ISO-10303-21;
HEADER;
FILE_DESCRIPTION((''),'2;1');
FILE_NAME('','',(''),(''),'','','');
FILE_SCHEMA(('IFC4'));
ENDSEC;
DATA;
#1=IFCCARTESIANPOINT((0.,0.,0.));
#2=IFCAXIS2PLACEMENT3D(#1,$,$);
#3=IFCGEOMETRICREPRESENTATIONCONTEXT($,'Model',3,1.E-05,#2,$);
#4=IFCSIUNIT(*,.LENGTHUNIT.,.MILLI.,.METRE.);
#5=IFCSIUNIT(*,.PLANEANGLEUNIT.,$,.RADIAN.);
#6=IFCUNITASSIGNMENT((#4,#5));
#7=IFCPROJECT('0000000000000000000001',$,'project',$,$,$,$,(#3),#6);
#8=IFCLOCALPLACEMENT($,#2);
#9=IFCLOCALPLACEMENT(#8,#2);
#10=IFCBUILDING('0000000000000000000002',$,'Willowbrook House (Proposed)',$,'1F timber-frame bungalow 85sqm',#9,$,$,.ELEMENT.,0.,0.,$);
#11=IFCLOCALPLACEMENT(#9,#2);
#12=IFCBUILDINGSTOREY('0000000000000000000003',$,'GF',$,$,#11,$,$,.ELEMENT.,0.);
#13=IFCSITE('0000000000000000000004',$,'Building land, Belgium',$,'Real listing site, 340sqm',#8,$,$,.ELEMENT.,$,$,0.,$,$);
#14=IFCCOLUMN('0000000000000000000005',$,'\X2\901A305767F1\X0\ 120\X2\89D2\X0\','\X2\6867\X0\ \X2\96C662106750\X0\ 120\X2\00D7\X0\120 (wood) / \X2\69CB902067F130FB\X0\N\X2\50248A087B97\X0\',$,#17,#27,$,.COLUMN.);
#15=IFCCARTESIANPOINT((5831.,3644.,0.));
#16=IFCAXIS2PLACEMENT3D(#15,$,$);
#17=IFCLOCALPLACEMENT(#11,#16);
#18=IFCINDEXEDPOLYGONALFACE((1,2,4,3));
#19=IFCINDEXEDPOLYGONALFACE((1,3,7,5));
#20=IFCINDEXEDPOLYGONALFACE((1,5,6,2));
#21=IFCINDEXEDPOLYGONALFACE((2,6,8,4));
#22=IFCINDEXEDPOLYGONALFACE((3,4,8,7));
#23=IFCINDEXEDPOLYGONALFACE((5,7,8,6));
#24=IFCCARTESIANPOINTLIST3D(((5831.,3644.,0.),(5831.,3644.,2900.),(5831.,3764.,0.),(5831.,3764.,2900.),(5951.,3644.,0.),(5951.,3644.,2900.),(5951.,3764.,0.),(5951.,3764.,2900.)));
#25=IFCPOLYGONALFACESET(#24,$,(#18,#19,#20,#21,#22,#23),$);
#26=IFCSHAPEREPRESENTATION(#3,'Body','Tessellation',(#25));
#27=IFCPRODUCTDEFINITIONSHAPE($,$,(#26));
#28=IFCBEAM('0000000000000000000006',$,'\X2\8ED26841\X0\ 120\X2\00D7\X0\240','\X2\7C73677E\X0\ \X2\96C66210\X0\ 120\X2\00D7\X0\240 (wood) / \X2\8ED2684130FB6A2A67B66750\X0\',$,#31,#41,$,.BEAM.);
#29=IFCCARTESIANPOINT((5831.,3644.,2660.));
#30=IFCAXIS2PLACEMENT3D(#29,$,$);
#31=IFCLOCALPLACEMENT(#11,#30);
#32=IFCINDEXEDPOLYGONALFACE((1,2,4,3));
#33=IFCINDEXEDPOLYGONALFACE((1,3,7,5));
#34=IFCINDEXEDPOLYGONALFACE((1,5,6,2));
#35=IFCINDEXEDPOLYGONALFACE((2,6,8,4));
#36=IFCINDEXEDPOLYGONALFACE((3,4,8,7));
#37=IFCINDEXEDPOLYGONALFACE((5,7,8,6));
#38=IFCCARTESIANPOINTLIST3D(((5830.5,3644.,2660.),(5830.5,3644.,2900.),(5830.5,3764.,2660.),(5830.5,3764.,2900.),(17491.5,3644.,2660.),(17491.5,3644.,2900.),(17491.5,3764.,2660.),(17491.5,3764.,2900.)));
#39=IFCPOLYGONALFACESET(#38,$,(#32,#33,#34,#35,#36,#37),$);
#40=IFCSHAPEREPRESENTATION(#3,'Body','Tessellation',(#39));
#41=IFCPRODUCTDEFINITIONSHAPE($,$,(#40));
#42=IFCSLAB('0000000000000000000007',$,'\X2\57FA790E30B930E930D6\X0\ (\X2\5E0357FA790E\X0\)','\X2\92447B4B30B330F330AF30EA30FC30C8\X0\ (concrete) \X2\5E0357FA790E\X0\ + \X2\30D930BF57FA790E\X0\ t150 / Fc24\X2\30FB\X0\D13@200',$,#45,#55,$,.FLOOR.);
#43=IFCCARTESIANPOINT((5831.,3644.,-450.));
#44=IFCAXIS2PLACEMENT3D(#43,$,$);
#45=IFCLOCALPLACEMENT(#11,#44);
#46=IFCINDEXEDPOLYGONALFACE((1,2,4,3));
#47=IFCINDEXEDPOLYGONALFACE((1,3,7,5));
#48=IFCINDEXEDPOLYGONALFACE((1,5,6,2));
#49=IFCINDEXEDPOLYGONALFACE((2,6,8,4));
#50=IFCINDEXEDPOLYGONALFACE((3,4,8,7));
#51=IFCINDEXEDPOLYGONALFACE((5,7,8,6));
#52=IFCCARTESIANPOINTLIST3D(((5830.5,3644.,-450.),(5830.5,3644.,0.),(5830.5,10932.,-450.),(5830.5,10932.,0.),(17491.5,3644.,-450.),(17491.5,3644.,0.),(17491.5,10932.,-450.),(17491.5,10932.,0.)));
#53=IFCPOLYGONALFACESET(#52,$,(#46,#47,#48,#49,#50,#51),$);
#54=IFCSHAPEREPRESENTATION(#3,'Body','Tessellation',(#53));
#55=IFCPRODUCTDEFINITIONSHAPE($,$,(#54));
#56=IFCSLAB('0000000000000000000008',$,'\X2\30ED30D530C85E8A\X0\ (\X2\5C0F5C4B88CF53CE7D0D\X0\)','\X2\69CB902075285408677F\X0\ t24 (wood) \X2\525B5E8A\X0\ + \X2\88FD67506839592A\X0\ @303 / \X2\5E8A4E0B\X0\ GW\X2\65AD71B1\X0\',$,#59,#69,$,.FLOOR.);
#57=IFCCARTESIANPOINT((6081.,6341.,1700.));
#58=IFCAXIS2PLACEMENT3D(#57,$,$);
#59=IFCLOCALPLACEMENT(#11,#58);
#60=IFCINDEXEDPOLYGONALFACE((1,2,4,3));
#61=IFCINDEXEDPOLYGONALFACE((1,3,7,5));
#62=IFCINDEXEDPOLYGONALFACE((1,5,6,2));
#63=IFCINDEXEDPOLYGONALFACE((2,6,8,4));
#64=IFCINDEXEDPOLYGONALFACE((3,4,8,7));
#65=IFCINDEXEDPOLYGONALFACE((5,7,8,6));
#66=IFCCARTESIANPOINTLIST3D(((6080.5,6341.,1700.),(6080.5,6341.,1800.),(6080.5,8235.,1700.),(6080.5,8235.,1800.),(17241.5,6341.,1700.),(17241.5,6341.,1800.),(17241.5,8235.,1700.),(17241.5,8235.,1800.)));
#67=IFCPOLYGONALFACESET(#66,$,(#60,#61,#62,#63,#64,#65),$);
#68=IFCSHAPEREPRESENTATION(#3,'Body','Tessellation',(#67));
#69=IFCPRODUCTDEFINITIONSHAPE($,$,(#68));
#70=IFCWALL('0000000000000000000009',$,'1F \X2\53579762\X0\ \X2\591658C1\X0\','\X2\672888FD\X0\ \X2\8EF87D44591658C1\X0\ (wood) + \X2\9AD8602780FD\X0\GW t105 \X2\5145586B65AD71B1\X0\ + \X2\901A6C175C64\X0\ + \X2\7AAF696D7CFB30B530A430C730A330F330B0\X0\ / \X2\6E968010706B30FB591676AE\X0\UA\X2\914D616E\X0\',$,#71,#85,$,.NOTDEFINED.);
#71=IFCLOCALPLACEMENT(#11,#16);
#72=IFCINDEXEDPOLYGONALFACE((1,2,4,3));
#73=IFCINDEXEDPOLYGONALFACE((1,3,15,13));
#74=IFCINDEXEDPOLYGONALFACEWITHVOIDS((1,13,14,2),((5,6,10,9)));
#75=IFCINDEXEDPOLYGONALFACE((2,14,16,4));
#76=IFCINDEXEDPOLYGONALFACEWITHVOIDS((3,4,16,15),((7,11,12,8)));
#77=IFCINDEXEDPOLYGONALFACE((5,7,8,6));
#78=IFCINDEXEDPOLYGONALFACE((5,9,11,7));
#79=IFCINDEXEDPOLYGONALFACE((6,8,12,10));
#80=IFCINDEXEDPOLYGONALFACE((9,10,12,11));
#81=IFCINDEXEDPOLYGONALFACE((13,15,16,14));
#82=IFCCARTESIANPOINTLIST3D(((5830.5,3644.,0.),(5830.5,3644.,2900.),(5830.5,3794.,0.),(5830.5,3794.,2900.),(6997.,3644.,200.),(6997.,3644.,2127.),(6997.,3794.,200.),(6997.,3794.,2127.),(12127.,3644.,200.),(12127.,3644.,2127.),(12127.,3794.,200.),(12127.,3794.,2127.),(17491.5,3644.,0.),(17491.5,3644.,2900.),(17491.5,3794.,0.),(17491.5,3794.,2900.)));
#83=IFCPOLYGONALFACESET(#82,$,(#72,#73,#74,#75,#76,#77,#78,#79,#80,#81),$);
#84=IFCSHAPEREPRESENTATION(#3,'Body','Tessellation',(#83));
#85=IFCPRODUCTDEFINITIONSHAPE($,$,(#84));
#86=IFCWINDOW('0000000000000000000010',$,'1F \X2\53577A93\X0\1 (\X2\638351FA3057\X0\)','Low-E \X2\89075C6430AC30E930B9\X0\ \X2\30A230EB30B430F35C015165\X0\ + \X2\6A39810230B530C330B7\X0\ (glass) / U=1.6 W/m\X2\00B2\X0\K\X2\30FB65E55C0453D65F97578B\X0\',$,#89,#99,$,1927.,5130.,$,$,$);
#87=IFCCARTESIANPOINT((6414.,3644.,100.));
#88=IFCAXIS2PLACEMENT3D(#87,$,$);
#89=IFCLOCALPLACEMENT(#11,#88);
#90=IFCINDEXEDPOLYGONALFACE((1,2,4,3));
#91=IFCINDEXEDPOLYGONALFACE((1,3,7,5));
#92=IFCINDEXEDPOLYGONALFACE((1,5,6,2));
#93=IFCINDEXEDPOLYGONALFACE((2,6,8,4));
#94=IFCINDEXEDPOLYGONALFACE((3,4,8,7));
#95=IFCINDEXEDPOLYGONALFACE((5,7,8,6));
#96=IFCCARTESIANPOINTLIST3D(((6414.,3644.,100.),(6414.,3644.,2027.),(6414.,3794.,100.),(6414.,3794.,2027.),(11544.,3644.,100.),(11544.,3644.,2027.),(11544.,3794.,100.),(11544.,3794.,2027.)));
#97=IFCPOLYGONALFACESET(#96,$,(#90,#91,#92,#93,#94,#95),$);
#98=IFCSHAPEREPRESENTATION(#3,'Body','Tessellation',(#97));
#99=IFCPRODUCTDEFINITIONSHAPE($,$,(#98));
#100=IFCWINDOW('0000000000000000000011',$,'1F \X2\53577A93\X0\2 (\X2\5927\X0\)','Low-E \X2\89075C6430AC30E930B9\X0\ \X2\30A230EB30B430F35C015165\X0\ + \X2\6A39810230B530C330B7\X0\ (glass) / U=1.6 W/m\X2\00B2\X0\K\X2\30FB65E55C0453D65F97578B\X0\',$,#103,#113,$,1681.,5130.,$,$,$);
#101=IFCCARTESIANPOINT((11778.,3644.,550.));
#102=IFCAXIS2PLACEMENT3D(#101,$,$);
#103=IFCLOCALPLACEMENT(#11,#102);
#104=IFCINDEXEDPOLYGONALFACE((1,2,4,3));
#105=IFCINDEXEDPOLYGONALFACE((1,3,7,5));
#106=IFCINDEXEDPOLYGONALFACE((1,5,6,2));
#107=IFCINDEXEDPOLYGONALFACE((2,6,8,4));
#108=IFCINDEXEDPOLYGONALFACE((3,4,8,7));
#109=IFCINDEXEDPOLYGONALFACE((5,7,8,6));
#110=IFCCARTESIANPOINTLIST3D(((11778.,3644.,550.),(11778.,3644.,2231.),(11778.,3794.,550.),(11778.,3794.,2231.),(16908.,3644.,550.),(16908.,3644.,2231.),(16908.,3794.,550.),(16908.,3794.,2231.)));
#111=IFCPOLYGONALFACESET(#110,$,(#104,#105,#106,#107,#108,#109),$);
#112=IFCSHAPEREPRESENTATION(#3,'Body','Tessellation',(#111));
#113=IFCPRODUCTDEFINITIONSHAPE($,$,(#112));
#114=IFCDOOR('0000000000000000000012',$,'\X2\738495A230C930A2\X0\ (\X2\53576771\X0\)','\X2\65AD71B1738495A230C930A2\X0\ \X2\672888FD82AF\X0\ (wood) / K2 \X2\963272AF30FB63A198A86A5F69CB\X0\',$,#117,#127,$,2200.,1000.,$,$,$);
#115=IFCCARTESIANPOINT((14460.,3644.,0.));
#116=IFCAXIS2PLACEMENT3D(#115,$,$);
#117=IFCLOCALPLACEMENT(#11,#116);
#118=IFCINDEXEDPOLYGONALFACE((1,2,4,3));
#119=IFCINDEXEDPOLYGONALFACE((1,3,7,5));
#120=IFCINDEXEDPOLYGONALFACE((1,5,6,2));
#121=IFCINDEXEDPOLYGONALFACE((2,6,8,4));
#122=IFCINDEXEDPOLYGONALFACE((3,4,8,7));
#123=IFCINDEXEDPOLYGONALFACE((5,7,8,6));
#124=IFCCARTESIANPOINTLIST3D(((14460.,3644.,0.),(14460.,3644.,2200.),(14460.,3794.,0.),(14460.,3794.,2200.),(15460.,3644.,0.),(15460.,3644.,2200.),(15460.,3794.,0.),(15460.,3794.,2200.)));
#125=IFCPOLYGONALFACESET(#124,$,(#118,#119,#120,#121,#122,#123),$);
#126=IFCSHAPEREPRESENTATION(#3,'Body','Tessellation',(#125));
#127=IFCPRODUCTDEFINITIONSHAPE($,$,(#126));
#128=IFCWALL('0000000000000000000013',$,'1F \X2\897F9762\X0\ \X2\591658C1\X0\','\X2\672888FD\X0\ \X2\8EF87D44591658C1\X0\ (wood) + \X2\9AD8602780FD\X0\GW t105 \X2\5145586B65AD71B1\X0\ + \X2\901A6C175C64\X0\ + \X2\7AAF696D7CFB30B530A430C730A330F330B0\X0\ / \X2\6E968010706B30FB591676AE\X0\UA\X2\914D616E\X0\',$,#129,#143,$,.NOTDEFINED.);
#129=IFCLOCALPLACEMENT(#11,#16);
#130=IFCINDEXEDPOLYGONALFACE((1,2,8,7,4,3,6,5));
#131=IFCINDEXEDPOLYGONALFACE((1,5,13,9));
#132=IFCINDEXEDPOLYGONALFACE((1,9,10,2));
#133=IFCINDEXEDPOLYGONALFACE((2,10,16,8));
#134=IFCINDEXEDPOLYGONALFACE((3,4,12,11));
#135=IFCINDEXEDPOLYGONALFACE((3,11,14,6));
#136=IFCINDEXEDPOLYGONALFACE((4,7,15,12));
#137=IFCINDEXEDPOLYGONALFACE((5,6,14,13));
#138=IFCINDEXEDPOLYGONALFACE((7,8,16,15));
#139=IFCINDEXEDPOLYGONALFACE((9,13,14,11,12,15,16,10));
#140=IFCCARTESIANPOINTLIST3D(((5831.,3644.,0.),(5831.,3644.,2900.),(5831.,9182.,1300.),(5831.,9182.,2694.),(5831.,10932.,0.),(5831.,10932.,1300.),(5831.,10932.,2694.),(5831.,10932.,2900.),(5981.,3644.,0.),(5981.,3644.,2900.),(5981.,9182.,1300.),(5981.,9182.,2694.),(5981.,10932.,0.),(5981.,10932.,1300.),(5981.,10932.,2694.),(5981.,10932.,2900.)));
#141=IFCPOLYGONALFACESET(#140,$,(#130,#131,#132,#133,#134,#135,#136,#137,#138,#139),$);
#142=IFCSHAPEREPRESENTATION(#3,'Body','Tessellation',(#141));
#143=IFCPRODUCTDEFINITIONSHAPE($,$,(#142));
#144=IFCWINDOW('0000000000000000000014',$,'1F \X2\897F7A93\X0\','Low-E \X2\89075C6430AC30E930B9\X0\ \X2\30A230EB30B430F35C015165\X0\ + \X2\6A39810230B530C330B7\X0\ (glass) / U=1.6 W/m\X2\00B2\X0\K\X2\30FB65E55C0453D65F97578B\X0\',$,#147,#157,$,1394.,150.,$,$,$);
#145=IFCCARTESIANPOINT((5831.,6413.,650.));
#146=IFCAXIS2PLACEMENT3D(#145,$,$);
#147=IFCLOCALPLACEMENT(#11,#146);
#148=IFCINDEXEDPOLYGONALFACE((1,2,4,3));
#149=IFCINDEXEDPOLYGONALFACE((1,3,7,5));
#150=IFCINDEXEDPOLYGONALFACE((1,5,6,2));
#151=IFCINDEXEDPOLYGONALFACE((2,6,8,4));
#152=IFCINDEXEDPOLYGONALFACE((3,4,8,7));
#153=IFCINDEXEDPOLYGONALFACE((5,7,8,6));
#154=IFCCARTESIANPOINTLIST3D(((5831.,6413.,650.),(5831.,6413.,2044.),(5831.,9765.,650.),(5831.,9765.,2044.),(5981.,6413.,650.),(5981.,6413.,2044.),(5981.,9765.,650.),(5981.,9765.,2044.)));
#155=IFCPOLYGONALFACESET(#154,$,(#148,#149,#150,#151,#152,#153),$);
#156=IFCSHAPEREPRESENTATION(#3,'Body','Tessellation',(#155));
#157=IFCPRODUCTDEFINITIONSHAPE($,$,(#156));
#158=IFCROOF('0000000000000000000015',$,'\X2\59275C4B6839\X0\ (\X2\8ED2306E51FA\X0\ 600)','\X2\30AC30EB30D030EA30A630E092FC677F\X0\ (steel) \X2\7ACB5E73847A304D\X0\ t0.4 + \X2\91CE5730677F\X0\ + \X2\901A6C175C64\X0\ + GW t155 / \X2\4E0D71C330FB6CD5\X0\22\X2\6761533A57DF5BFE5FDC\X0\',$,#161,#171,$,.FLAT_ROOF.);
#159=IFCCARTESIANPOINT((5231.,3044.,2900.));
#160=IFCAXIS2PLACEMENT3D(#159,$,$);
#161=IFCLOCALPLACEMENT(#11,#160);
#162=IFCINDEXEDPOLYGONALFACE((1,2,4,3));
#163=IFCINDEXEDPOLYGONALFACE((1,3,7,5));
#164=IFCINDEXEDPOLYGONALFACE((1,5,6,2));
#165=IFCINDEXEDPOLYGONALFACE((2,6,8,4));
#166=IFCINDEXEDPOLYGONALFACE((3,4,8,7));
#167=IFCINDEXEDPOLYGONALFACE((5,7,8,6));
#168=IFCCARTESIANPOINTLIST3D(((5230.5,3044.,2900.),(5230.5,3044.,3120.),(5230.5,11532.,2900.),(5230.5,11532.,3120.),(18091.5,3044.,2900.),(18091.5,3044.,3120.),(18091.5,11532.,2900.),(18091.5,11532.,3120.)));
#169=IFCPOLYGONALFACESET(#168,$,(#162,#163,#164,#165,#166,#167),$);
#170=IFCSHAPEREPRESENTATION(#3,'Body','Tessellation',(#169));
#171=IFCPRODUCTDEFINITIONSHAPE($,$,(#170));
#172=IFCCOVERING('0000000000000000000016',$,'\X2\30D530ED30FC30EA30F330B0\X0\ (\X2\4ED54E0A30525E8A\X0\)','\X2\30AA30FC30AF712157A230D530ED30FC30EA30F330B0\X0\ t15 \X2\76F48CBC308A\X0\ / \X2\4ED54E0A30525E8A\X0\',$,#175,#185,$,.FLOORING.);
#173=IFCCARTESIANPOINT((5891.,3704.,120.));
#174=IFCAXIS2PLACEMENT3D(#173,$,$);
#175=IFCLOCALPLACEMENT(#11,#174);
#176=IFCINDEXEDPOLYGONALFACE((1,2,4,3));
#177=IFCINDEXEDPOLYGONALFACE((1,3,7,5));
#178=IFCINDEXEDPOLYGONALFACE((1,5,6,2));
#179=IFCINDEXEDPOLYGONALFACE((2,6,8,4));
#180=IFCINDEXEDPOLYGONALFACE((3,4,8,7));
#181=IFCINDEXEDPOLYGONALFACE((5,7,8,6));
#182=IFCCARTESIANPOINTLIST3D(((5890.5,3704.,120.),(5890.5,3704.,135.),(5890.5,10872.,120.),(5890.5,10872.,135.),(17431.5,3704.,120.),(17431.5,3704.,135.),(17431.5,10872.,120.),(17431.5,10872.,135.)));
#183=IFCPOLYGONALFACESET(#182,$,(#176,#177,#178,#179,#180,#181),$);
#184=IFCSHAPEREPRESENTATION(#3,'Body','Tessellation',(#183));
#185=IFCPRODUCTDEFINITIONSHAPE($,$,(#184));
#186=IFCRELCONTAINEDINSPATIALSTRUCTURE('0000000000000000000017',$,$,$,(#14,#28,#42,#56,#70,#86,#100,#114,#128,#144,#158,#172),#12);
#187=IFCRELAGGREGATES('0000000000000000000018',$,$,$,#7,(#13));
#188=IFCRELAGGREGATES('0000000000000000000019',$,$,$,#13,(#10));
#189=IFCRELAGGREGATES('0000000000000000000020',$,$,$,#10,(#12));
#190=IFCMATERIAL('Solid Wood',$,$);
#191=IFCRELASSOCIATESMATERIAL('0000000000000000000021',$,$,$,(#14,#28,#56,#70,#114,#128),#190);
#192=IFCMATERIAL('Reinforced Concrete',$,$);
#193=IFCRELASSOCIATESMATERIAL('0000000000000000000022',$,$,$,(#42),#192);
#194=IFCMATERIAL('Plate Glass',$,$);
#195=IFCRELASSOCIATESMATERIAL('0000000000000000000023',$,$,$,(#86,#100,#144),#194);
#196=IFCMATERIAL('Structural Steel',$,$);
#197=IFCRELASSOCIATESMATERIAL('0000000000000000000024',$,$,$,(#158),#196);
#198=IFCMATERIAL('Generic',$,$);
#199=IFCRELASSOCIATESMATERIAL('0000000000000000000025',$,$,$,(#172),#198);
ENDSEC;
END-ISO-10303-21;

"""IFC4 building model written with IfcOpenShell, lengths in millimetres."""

from ifc_helpers import new_model, si_unit, frame, frame_2d, origin, place, context, project, spatial, rectangle, extrude, material, element, fill, save


model = new_model("IFC4")

# Units and contexts
model_context = context("Model", 3, precision=1e-05, world=origin())
ifc_project = project(units=[si_unit("LENGTHUNIT", "METRE", prefix="MILLI"), si_unit("PLANEANGLEUNIT", "RADIAN")], contexts=[model_context])

# Site, building, storey
site_placement = place(None, origin())
site = spatial("IfcSite", under=ifc_project, at=site_placement, Name="Building land, Belgium", ObjectType="Real listing site, 340sqm", CompositionType="ELEMENT", RefElevation=0.0)
building_placement = place(site_placement, origin())
building = spatial("IfcBuilding", under=site, at=building_placement, Name="Willowbrook House (Proposed)", ObjectType="1F timber-frame bungalow 85sqm", CompositionType="ELEMENT", ElevationOfRefHeight=0.0, ElevationOfTerrain=0.0)
storey_placement = place(building_placement, origin())
storey = spatial("IfcBuildingStorey", under=building, at=storey_placement, Name="GF", CompositionType="ELEMENT", Elevation=0.0)

# Column
ifc_material_1 = material(Name="Solid Wood")
column_1_placement = place(storey_placement, frame((5831.0, 3644.0, 0.0)))
element("IfcColumn", 1, at=column_1_placement, inside=storey, material=ifc_material_1, Name="通し柱 120角", Description="桧 集成材 120×120 (wood) / 構造柱・N値計算", PredefinedType="COLUMN", context=model_context, shape_type="SweptSolid", body=[
    extrude(rectangle(XDim=120.0, YDim=120.0, at=frame_2d((60.0, 60.0))), frame((5831.0, 3644.0, 0.0)), (0.0, 0.0, 1.0), 2900.0),
])

# Beam
beam_1_placement = place(storey_placement, frame((5831.0, 3644.0, 2660.0)))
element("IfcBeam", 2, at=beam_1_placement, inside=storey, material=ifc_material_1, Name="軒桁 120×240", Description="米松 集成 120×240 (wood) / 軒桁・横架材", PredefinedType="BEAM", context=model_context, shape_type="SweptSolid", body=[
    extrude(rectangle(XDim=11661.0, YDim=120.0, at=frame_2d((5830.0, 60.0))), frame((5831.0, 3644.0, 2660.0)), (0.0, 0.0, 1.0), 240.0),
])

# Slabs
ifc_material_2 = material(Name="Reinforced Concrete")
slab_1_placement = place(storey_placement, frame((5831.0, 3644.0, -450.0)))
element("IfcSlab", 3, at=slab_1_placement, inside=storey, material=ifc_material_2, Name="基礎スラブ (布基礎)", Description="鉄筋コンクリート (concrete) 布基礎 + ベタ基礎 t150 / Fc24・D13@200", PredefinedType="FLOOR", context=model_context, shape_type="SweptSolid", body=[
    extrude(rectangle(XDim=11661.0, YDim=7288.0, at=frame_2d((5830.0, 3644.0))), frame((5831.0, 3644.0, -450.0)), (0.0, 0.0, 1.0), 450.0),
])
slab_2_placement = place(storey_placement, frame((6081.0, 6341.0, 1700.0)))
element("IfcSlab", 4, at=slab_2_placement, inside=storey, material=ifc_material_1, Name="ロフト床 (小屋裏収納)", Description="構造用合板 t24 (wood) 剛床 + 製材根太 @303 / 床下 GW断熱", PredefinedType="FLOOR", context=model_context, shape_type="SweptSolid", body=[
    extrude(rectangle(XDim=11161.0, YDim=1894.0, at=frame_2d((5580.0, 947.0))), frame((6081.0, 6341.0, 1700.0)), (0.0, 0.0, 1.0), 100.0),
])

# Wall, openings, windows, door
wall_1_placement = place(storey_placement, frame((5831.0, 3644.0, 0.0)))
wall_1 = element("IfcWall", 5, at=wall_1_placement, inside=storey, material=ifc_material_1, Name="1F 南面 外壁", Description="木製 軸組外壁 (wood) + 高性能GW t105 充填断熱 + 通気層 + 窯業系サイディング / 準耐火・外皮UA配慮", PredefinedType="NOTDEFINED", context=model_context, shape_type="SweptSolid", body=[
    extrude(rectangle(XDim=11661.0, YDim=150.0, at=frame_2d((5830.0, 75.0))), frame((5831.0, 3644.0, 0.0)), (0.0, 0.0, 1.0), 2900.0),
])
opening_1_placement = place(storey_placement, frame((6414.0, 3644.0, 100.0)))
opening_1 = element("IfcOpeningElement", 6, at=opening_1_placement, cuts=wall_1, PredefinedType="NOTDEFINED", context=model_context, shape_type="SweptSolid", body=[
    extrude(rectangle(XDim=5130.0, YDim=150.0, at=frame_2d((2565.0, 75.0))), frame((6414.0, 3644.0, 100.0)), (0.0, 0.0, 1.0), 1927.0),
])
opening_2_placement = place(storey_placement, frame((11778.0, 3644.0, 550.0)))
opening_2 = element("IfcOpeningElement", 7, at=opening_2_placement, cuts=wall_1, PredefinedType="NOTDEFINED", context=model_context, shape_type="SweptSolid", body=[
    extrude(rectangle(XDim=5130.0, YDim=150.0, at=frame_2d((2565.0, 75.0))), frame((11778.0, 3644.0, 550.0)), (0.0, 0.0, 1.0), 1681.0),
])
opening_3_placement = place(storey_placement, frame((14460.0, 3644.0, 0.0)))
opening_3 = element("IfcOpeningElement", 8, at=opening_3_placement, cuts=wall_1, PredefinedType="NOTDEFINED", context=model_context, shape_type="SweptSolid", body=[
    extrude(rectangle(XDim=1000.0, YDim=150.0, at=frame_2d((500.0, 75.0))), frame((14460.0, 3644.0, 0.0)), (0.0, 0.0, 1.0), 2200.0),
])
ifc_material_3 = material(Name="Plate Glass")
window_1_placement = place(storey_placement, frame((6414.0, 3644.0, 100.0)))
window_1 = element("IfcWindow", 9, at=window_1_placement, inside=storey, material=ifc_material_3, Name="1F 南窓1 (掃出し)", Description="Low-E 複層ガラス アルゴン封入 + 樹脂サッシ (glass) / U=1.6 W/m²K・日射取得型", OverallHeight=1927.0, OverallWidth=5130.0, context=model_context, shape_type="SweptSolid", body=[
    extrude(rectangle(XDim=5130.0, YDim=150.0, at=frame_2d((2565.0, 75.0))), frame((6414.0, 3644.0, 100.0)), (0.0, 0.0, 1.0), 1927.0),
])
fill(opening_1, window_1)
window_2_placement = place(storey_placement, frame((11778.0, 3644.0, 550.0)))
window_2 = element("IfcWindow", 10, at=window_2_placement, inside=storey, material=ifc_material_3, Name="1F 南窓2 (大)", Description="Low-E 複層ガラス アルゴン封入 + 樹脂サッシ (glass) / U=1.6 W/m²K・日射取得型", OverallHeight=1681.0, OverallWidth=5130.0, context=model_context, shape_type="SweptSolid", body=[
    extrude(rectangle(XDim=5130.0, YDim=150.0, at=frame_2d((2565.0, 75.0))), frame((11778.0, 3644.0, 550.0)), (0.0, 0.0, 1.0), 1681.0),
])
fill(opening_2, window_2)
door_placement = place(storey_placement, frame((14460.0, 3644.0, 0.0)))
door = element("IfcDoor", 11, at=door_placement, inside=storey, material=ifc_material_1, Name="玄関ドア (南東)", Description="断熱玄関ドア 木製芯 (wood) / K2 防犯・採風機構", OverallHeight=2200.0, OverallWidth=1000.0, context=model_context, shape_type="SweptSolid", body=[
    extrude(rectangle(XDim=1000.0, YDim=150.0, at=frame_2d((500.0, 75.0))), frame((14460.0, 3644.0, 0.0)), (0.0, 0.0, 1.0), 2200.0),
])
fill(opening_3, door)

# Wall, opening, window
wall_2_placement = place(storey_placement, frame((5831.0, 3644.0, 0.0)))
wall_2 = element("IfcWall", 12, at=wall_2_placement, inside=storey, material=ifc_material_1, Name="1F 西面 外壁", Description="木製 軸組外壁 (wood) + 高性能GW t105 充填断熱 + 通気層 + 窯業系サイディング / 準耐火・外皮UA配慮", PredefinedType="NOTDEFINED", context=model_context, shape_type="SweptSolid", body=[
    extrude(rectangle(XDim=150.0, YDim=7288.0, at=frame_2d((75.0, 3644.0))), frame((5831.0, 3644.0, 0.0)), (0.0, 0.0, 1.0), 2900.0),
])
opening_4_placement = place(storey_placement, frame((5831.0, 6413.0, 650.0)))
opening_4 = element("IfcOpeningElement", 13, at=opening_4_placement, cuts=wall_2, PredefinedType="NOTDEFINED", context=model_context, shape_type="SweptSolid", body=[
    extrude(rectangle(XDim=150.0, YDim=3352.0, at=frame_2d((75.0, 1676.0))), frame((5831.0, 6413.0, 650.0)), (0.0, 0.0, 1.0), 1394.0),
])
window_3_placement = place(storey_placement, frame((5831.0, 6413.0, 650.0)))
window_3 = element("IfcWindow", 14, at=window_3_placement, inside=storey, material=ifc_material_3, Name="1F 西窓", Description="Low-E 複層ガラス アルゴン封入 + 樹脂サッシ (glass) / U=1.6 W/m²K・日射取得型", OverallHeight=1394.0, OverallWidth=150.0, context=model_context, shape_type="SweptSolid", body=[
    extrude(rectangle(XDim=150.0, YDim=3352.0, at=frame_2d((75.0, 1676.0))), frame((5831.0, 6413.0, 650.0)), (0.0, 0.0, 1.0), 1394.0),
])
fill(opening_4, window_3)

# Roof
ifc_material_4 = material(Name="Structural Steel")
roof_placement = place(storey_placement, frame((5231.0, 3044.0, 2900.0)))
element("IfcRoof", 15, at=roof_placement, inside=storey, material=ifc_material_4, Name="大屋根 (軒の出 600)", Description="ガルバリウム鋼板 (steel) 立平葺き t0.4 + 野地板 + 通気層 + GW t155 / 不燃・法22条区域対応", PredefinedType="FLAT_ROOF", context=model_context, shape_type="SweptSolid", body=[
    extrude(rectangle(XDim=12861.0, YDim=8488.0, at=frame_2d((6430.0, 4244.0))), frame((5231.0, 3044.0, 2900.0)), (0.0, 0.0, 1.0), 220.0),
])

# Covering
ifc_material_5 = material(Name="Generic")
covering_1_placement = place(storey_placement, frame((5891.0, 3704.0, 120.0)))
element("IfcCovering", 16, at=covering_1_placement, inside=storey, material=ifc_material_5, Name="フローリング (仕上げ床)", Description="オーク無垢フローリング t15 直貼り / 仕上げ床", PredefinedType="FLOORING", context=model_context, shape_type="SweptSolid", body=[
    extrude(rectangle(XDim=11541.0, YDim=7168.0, at=frame_2d((5770.0, 3584.0))), frame((5891.0, 3704.0, 120.0)), (0.0, 0.0, 1.0), 15.0),
])

save(model, "model.ifc")
